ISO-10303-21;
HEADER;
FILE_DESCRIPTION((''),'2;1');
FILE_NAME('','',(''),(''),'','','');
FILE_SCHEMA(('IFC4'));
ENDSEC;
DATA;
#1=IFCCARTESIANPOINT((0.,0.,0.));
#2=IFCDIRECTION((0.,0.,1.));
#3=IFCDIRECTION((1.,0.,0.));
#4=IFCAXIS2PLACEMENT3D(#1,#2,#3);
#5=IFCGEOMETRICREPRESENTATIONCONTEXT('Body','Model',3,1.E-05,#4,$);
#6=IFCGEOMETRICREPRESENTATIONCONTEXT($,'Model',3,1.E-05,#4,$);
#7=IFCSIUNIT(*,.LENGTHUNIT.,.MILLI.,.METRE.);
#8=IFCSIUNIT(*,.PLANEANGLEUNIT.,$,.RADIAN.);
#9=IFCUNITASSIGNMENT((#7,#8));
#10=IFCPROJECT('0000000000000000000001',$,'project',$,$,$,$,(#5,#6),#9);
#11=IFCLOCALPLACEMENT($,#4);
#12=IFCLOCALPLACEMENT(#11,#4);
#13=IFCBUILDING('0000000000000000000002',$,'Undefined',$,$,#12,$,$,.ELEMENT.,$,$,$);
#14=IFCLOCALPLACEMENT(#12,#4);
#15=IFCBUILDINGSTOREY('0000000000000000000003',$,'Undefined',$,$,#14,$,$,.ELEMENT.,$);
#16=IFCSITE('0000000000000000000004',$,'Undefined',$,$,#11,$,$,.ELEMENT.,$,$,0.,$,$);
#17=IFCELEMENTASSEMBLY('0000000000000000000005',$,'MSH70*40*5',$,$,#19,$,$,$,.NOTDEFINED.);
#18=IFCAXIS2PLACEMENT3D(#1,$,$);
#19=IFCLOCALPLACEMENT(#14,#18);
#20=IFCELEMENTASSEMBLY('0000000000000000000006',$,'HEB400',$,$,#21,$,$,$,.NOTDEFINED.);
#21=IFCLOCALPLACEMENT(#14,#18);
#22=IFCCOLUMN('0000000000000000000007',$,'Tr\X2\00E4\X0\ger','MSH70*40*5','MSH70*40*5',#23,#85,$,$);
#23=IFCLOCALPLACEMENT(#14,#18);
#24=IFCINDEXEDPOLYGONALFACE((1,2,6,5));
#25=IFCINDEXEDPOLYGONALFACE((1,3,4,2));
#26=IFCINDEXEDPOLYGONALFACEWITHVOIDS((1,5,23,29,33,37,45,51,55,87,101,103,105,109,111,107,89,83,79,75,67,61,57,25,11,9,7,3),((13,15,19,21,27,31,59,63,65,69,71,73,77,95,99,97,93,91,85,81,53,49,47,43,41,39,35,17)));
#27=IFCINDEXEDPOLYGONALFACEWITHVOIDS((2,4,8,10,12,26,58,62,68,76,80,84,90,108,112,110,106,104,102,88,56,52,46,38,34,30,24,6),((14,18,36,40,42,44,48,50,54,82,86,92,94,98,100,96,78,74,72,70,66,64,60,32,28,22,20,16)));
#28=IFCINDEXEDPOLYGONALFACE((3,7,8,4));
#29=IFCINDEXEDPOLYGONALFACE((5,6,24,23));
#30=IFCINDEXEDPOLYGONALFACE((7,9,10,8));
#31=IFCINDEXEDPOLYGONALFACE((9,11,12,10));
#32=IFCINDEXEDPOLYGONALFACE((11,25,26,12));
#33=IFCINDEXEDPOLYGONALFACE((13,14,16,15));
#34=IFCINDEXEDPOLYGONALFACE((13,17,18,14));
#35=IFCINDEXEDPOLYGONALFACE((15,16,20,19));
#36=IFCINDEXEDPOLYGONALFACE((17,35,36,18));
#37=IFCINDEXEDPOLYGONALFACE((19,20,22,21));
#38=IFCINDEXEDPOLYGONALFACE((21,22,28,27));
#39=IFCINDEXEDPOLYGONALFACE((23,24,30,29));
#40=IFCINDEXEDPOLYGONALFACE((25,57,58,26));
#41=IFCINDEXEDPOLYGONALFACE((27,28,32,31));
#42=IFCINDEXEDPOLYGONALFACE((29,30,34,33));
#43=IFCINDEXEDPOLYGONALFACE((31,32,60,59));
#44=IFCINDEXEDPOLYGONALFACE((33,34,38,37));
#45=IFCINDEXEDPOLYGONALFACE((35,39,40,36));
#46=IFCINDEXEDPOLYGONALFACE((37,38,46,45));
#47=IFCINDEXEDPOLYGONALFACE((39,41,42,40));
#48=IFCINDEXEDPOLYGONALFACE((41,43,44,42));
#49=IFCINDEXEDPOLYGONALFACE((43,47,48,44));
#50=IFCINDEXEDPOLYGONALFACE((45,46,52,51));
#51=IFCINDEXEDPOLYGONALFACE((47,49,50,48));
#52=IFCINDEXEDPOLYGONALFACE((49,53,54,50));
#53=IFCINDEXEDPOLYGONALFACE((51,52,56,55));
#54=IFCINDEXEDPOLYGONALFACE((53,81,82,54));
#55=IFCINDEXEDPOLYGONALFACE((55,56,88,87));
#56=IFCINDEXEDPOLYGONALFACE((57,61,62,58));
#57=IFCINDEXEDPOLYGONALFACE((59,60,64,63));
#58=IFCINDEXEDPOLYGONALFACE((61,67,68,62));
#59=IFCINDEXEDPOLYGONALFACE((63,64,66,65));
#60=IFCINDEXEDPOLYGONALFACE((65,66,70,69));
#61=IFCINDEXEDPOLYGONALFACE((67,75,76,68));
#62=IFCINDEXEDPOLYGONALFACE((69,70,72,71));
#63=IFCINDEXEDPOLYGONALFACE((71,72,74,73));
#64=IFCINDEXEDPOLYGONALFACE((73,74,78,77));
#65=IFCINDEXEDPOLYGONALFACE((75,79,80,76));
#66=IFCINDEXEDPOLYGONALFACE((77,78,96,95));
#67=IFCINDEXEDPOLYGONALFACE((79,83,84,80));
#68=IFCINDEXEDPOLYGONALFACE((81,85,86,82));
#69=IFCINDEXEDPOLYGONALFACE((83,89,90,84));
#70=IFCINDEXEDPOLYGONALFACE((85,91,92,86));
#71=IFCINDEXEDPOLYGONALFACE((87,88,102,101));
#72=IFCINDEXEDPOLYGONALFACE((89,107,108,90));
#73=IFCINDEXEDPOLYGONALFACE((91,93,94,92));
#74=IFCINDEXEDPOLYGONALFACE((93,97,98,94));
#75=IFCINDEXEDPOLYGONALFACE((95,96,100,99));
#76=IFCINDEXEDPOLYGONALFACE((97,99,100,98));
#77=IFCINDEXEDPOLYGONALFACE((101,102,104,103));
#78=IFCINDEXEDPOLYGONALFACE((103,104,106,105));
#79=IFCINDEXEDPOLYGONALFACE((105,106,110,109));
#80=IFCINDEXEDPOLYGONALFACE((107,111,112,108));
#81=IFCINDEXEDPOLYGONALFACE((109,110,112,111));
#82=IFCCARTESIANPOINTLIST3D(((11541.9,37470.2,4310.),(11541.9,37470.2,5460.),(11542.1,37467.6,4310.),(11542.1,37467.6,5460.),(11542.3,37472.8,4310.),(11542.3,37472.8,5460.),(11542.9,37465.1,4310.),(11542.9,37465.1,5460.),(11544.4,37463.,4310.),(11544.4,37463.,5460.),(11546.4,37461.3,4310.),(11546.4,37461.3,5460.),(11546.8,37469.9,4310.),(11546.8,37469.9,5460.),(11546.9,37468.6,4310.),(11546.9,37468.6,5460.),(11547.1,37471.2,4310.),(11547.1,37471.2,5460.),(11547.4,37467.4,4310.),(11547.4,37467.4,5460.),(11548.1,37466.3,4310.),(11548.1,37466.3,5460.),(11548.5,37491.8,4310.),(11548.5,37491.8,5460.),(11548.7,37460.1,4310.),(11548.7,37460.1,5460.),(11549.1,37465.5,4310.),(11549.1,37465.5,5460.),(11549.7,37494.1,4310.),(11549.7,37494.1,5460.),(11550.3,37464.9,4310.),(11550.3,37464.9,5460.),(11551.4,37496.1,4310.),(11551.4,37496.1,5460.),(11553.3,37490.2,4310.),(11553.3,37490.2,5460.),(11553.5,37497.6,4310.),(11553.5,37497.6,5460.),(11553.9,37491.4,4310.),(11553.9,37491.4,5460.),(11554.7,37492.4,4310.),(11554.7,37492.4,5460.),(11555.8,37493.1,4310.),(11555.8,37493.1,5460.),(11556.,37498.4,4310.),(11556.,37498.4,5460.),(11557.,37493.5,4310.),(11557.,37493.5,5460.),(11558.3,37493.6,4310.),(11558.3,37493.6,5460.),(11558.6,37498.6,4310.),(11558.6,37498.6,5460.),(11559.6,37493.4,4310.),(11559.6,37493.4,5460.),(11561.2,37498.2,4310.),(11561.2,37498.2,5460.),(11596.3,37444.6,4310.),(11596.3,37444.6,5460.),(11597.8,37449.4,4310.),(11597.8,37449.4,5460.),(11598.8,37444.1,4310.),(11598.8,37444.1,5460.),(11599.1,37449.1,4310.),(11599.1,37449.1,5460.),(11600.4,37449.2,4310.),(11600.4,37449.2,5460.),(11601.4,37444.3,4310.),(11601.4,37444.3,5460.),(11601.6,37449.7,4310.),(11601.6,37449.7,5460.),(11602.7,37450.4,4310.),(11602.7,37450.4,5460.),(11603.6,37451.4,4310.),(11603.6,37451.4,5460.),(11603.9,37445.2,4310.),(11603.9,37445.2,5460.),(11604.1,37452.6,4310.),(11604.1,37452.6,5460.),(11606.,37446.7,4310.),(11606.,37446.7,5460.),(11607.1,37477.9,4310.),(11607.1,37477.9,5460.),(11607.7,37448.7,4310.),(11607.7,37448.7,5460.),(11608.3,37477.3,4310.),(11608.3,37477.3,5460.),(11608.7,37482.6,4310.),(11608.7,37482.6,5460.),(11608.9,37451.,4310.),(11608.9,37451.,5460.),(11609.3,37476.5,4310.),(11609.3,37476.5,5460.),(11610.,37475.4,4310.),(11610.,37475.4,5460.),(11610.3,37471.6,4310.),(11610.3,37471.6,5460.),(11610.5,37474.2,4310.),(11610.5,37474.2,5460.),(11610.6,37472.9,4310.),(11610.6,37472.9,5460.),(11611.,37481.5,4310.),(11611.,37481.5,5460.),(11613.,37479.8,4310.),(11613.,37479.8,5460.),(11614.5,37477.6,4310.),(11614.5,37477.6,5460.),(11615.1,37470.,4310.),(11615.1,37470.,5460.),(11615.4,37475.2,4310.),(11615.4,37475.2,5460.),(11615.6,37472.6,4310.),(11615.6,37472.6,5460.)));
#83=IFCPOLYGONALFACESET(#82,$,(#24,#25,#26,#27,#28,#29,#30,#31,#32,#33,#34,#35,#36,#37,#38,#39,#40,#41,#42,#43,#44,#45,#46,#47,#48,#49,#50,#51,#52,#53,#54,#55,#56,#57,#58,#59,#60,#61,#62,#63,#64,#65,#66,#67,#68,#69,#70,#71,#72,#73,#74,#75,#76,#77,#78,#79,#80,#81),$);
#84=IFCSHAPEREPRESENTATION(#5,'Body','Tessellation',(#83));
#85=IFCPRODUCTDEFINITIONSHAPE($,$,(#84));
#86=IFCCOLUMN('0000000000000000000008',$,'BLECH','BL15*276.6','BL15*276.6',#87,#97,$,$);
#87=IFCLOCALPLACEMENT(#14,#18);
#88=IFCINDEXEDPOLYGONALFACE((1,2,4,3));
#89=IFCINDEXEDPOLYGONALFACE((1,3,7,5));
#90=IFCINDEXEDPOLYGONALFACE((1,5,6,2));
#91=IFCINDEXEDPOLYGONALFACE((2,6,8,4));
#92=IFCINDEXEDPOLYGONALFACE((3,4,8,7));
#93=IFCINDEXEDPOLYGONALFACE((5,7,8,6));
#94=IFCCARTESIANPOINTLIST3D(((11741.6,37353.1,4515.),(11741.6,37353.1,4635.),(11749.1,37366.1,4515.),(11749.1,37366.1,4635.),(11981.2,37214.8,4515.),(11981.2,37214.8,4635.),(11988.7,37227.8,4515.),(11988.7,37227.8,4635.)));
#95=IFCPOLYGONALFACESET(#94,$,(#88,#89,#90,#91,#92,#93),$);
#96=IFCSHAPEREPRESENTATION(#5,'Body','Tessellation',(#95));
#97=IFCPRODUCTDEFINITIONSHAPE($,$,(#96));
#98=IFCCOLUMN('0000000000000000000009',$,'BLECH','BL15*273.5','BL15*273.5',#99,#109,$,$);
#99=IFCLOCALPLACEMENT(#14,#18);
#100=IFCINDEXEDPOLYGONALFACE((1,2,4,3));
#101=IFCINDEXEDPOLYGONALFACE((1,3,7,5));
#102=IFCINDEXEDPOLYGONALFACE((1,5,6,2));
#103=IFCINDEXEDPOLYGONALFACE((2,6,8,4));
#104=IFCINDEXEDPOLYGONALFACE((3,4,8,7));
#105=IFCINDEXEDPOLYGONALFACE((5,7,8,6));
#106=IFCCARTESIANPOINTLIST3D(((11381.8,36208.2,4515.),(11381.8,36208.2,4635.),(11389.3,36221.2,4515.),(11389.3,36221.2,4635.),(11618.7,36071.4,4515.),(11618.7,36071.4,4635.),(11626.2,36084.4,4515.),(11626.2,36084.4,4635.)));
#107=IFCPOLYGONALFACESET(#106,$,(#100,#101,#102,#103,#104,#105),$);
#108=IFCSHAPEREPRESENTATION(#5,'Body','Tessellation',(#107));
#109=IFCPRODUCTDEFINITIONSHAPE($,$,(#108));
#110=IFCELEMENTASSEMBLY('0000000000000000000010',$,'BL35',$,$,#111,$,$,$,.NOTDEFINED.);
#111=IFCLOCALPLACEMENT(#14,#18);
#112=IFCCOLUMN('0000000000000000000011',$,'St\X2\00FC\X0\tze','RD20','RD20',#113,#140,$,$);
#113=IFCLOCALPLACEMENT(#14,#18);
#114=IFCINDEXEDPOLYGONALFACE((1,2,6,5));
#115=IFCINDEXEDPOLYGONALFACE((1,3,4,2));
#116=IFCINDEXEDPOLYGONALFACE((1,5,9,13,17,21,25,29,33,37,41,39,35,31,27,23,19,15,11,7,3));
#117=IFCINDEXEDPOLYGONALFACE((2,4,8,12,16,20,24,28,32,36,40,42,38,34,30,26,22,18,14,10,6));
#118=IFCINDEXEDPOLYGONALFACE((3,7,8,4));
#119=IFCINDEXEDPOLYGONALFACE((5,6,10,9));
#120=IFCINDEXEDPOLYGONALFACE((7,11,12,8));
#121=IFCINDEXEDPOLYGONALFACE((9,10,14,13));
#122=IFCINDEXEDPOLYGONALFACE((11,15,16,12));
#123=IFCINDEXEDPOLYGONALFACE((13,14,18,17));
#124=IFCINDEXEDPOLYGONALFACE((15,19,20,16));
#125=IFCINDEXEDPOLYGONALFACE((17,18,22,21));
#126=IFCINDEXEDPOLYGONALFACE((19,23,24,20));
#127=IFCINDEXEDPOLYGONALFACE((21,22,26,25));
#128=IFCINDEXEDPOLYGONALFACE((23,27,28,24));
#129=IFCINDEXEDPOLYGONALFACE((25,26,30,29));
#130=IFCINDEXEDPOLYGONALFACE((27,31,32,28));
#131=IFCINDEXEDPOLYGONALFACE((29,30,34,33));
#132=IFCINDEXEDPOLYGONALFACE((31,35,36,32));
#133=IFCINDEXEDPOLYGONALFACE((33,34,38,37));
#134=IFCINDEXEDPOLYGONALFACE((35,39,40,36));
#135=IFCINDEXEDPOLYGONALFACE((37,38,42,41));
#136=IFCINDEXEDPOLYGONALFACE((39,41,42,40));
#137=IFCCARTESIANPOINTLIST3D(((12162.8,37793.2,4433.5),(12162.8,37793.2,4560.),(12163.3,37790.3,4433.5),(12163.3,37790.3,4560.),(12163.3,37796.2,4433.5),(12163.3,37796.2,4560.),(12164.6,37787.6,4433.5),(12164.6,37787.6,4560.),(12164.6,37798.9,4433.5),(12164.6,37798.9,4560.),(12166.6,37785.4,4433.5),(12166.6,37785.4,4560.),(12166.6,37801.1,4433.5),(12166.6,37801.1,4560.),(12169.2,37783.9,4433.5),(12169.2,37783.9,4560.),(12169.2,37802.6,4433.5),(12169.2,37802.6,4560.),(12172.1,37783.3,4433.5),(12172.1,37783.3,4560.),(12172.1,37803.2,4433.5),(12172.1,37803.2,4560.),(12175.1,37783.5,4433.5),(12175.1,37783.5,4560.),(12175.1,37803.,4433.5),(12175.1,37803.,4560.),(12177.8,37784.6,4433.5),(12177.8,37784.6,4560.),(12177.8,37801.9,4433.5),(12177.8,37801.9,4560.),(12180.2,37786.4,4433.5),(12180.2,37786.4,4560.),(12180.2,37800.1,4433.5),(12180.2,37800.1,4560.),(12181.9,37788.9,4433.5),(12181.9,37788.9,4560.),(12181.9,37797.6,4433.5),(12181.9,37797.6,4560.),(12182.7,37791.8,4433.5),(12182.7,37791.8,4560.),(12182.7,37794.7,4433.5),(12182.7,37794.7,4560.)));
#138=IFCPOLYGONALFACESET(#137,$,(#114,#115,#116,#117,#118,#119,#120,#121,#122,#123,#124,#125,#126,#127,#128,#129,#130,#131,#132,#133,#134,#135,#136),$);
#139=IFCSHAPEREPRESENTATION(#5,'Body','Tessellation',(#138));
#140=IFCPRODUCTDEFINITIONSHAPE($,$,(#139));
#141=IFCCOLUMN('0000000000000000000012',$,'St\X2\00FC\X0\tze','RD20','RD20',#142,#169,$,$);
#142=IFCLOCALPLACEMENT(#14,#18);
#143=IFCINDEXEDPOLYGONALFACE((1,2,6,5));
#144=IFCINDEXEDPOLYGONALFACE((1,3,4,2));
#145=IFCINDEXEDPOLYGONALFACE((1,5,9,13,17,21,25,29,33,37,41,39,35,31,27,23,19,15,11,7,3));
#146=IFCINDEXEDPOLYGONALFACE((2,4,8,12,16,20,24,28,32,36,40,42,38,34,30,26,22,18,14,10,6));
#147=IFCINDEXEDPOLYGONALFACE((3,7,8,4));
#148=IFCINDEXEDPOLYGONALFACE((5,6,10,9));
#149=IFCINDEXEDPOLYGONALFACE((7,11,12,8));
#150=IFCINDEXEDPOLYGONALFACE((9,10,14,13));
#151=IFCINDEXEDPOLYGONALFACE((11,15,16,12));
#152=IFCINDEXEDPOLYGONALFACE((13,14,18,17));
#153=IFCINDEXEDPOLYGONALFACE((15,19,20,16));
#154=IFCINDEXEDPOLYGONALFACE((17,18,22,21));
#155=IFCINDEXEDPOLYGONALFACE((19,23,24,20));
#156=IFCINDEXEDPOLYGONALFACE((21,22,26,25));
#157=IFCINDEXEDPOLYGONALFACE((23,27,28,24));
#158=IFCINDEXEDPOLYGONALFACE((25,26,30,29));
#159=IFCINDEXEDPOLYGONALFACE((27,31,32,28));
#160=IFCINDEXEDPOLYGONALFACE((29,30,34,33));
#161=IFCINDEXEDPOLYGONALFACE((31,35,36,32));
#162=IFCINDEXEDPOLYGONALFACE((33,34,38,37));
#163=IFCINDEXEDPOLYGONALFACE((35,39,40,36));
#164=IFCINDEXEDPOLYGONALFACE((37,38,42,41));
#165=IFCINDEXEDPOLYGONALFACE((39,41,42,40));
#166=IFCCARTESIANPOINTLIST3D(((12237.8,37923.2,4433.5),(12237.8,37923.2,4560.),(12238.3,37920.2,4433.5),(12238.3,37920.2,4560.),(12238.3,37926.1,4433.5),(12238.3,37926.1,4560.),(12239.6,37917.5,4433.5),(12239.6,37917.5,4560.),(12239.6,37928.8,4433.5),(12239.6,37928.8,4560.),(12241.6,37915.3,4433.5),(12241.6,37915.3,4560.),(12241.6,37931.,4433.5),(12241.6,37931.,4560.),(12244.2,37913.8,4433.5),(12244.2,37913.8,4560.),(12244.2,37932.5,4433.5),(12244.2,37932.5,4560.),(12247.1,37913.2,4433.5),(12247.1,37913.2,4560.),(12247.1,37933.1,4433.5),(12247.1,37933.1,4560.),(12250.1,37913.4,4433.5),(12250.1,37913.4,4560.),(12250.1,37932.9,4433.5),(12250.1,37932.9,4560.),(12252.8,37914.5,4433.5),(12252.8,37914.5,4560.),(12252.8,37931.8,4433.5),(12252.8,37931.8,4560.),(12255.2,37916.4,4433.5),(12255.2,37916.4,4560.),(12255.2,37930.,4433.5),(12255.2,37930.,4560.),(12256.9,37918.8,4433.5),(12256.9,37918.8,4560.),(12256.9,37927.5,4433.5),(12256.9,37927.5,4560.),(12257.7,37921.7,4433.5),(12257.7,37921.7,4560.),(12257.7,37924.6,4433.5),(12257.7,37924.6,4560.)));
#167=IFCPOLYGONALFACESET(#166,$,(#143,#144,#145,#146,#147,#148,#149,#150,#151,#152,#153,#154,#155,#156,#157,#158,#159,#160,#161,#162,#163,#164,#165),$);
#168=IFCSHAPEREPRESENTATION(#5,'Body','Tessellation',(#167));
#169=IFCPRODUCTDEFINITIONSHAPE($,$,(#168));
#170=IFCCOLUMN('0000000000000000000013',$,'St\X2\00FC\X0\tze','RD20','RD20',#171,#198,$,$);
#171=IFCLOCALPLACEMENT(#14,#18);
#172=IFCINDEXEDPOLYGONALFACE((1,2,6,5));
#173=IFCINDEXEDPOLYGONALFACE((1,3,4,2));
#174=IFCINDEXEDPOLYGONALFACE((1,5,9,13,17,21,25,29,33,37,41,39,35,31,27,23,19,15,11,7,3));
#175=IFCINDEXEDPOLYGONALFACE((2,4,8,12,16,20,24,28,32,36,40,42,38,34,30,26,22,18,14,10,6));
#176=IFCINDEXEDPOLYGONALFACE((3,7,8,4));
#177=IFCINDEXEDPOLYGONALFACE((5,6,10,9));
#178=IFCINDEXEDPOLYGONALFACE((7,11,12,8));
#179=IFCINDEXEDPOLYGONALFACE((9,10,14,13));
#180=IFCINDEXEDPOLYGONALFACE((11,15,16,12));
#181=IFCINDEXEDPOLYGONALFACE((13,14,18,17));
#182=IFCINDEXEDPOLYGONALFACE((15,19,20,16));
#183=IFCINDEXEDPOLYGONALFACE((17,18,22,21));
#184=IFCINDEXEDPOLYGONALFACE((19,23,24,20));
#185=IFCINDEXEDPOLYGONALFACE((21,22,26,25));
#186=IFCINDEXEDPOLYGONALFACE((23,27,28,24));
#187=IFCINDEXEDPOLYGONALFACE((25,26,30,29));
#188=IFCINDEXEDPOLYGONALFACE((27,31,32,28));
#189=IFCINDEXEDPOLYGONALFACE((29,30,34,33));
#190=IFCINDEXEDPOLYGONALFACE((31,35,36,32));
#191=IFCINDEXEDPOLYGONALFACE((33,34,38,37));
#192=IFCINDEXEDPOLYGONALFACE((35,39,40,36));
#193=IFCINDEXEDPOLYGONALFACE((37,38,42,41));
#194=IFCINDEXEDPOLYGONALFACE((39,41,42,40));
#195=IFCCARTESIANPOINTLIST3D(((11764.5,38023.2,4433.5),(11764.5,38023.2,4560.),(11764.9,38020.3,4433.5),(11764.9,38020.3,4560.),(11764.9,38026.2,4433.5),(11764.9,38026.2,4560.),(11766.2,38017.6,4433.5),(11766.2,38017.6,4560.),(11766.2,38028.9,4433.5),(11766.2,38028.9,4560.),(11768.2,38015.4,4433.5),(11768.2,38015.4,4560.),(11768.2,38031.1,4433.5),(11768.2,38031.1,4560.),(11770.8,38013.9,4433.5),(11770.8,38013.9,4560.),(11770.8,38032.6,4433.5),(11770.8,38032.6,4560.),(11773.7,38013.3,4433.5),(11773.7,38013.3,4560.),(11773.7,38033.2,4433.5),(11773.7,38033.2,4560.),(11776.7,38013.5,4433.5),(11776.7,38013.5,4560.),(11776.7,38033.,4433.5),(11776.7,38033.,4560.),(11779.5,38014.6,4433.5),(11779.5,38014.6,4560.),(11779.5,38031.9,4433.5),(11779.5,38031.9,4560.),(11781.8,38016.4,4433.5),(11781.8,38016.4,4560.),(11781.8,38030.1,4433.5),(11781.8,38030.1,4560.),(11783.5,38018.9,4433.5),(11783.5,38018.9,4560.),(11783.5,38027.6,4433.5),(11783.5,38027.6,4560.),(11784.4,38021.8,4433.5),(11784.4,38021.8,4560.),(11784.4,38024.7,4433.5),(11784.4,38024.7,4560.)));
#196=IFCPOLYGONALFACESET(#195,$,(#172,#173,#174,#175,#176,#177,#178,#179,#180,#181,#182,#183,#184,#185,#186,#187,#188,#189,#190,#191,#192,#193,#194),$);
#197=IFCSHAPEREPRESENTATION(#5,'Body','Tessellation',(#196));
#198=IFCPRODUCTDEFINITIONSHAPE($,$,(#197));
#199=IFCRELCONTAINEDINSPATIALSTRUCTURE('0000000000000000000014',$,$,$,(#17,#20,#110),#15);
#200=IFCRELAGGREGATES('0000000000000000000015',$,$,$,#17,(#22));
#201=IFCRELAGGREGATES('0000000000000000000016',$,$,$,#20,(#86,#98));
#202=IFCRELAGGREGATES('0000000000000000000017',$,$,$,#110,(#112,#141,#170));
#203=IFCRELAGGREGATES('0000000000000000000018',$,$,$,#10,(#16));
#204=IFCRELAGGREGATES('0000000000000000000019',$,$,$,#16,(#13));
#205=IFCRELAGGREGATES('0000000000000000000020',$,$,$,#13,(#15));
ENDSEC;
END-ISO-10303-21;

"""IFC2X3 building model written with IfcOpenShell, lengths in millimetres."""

from ifc_helpers import new_model, si_unit, frame, origin_with_axes, origin_2d_with_axis, place, context, project, spatial, rectangle, hollow_rectangle, circle, extrude, element, aggregate, save


model = new_model("IFC2X3")

# Units and contexts
model_context_1 = context("Model", 3, precision=1e-05, world=origin_with_axes(), identifier="Body")
model_context_2 = context("Model", 3, precision=1e-05, world=origin_with_axes())
ifc_project = project(units=[si_unit("LENGTHUNIT", "METRE", prefix="MILLI"), si_unit("PLANEANGLEUNIT", "RADIAN")], contexts=[model_context_1, model_context_2])

# Site, building, storey
site_placement = place(None, origin_with_axes())
site = spatial("IfcSite", under=ifc_project, at=site_placement, Name="Undefined", CompositionType="ELEMENT", RefElevation=0.0)
building_placement = place(site_placement, origin_with_axes())
building = spatial("IfcBuilding", under=site, at=building_placement, Name="Undefined", CompositionType="ELEMENT")
storey_placement = place(building_placement, origin_with_axes())
storey = spatial("IfcBuildingStorey", under=building, at=storey_placement, Name="Undefined", CompositionType="ELEMENT")

# Element assembly
assembly_1 = element("IfcElementAssembly", 1, inside=storey, Name="MSH70*40*5", PredefinedType="NOTDEFINED")

# Element assembly
assembly_2 = element("IfcElementAssembly", 2, inside=storey, Name="HEB400", PredefinedType="NOTDEFINED")

# Columns
column_1_placement = place(storey_placement, frame((11578.7, 37471.4, 4310.0), z_axis=(0.0, 0.0, 1.0), x_axis=(1.0, 0.0, 0.0)))
column_1 = element("IfcColumn", 3, at=column_1_placement, Name="Träger", Description="MSH70*40*5", ObjectType="MSH70*40*5", context=model_context_1, shape_type="SweptSolid", body=[
    extrude(hollow_rectangle(XDim=40.0, YDim=70.0, WallThickness=5.0, InnerFilletRadius=5.0, OuterFilletRadius=10.0, at=origin_2d_with_axis()), frame((0.0, 0.0, 1150.0), z_axis=(0.0, 0.0, -1.0), x_axis=(-0.310676, -0.950516, 0.0)), (0.0, 0.0, 1.0), 1150.0),
])
aggregate(assembly_1, [column_1])
column_2_placement = place(storey_placement, frame((11865.2, 37290.5, 4515.0), z_axis=(0.0, 0.0, 1.0), x_axis=(1.0, 0.0, 0.0)))
column_2 = element("IfcColumn", 4, at=column_2_placement, Name="BLECH", Description="BL15*276.6", ObjectType="BL15*276.6", context=model_context_1, shape_type="SweptSolid", body=[
    extrude(rectangle(XDim=15.0, YDim=276.6, at=origin_2d_with_axis()), frame((0.0, 0.0, 120.0), z_axis=(0.0, 0.0, -1.0), x_axis=(-0.500001, -0.866025, 0.0)), (0.0, 0.0, 1.0), 120.0),
])
column_3_placement = place(storey_placement, frame((11504.0, 36146.3, 4515.0), z_axis=(0.0, 0.0, 1.0), x_axis=(1.0, 0.0, 0.0)))
column_3 = element("IfcColumn", 5, at=column_3_placement, Name="BLECH", Description="BL15*273.5", ObjectType="BL15*273.5", context=model_context_1, shape_type="SweptSolid", body=[
    extrude(rectangle(XDim=15.0, YDim=273.5, at=origin_2d_with_axis()), frame((0.0, 0.0, 120.0), z_axis=(0.0, 0.0, -1.0), x_axis=(-0.500001, -0.866025, 0.0)), (0.0, 0.0, 1.0), 120.0),
])
aggregate(assembly_2, [column_2, column_3])

# Element assembly, columns
assembly_3 = element("IfcElementAssembly", 6, inside=storey, Name="BL35", PredefinedType="NOTDEFINED")
column_4_placement = place(storey_placement, frame((12172.8, 37793.2, 4433.5), z_axis=(0.0, 0.0, 1.0), x_axis=(1.0, 0.0, 0.0)))
column_4 = element("IfcColumn", 7, at=column_4_placement, Name="Stütze", Description="RD20", ObjectType="RD20", context=model_context_1, shape_type="SweptSolid", body=[
    extrude(circle(Radius=10.0, at=origin_2d_with_axis()), frame((0.0, 0.0, 126.5), z_axis=(0.0, 0.0, -1.0), x_axis=(0.5, 0.866025, 0.0)), (0.0, 0.0, 1.0), 126.5),
])
column_5_placement = place(storey_placement, frame((12247.8, 37923.2, 4433.5), z_axis=(0.0, 0.0, 1.0), x_axis=(1.0, 0.0, 0.0)))
column_5 = element("IfcColumn", 8, at=column_5_placement, Name="Stütze", Description="RD20", ObjectType="RD20", context=model_context_1, shape_type="SweptSolid", body=[
    extrude(circle(Radius=10.0, at=origin_2d_with_axis()), frame((0.0, 0.0, 126.5), z_axis=(0.0, 0.0, -1.0), x_axis=(0.5, 0.866025, 0.0)), (0.0, 0.0, 1.0), 126.5),
])
column_6_placement = place(storey_placement, frame((11774.5, 38023.2, 4433.5), z_axis=(0.0, 0.0, 1.0), x_axis=(1.0, 0.0, 0.0)))
column_6 = element("IfcColumn", 9, at=column_6_placement, Name="Stütze", Description="RD20", ObjectType="RD20", context=model_context_1, shape_type="SweptSolid", body=[
    extrude(circle(Radius=10.0, at=origin_2d_with_axis()), frame((0.0, 0.0, 126.5), z_axis=(0.0, 0.0, -1.0), x_axis=(0.5, 0.866025, 0.0)), (0.0, 0.0, 1.0), 126.5),
])
aggregate(assembly_3, [column_4, column_5, column_6])

save(model, "model.ifc")
